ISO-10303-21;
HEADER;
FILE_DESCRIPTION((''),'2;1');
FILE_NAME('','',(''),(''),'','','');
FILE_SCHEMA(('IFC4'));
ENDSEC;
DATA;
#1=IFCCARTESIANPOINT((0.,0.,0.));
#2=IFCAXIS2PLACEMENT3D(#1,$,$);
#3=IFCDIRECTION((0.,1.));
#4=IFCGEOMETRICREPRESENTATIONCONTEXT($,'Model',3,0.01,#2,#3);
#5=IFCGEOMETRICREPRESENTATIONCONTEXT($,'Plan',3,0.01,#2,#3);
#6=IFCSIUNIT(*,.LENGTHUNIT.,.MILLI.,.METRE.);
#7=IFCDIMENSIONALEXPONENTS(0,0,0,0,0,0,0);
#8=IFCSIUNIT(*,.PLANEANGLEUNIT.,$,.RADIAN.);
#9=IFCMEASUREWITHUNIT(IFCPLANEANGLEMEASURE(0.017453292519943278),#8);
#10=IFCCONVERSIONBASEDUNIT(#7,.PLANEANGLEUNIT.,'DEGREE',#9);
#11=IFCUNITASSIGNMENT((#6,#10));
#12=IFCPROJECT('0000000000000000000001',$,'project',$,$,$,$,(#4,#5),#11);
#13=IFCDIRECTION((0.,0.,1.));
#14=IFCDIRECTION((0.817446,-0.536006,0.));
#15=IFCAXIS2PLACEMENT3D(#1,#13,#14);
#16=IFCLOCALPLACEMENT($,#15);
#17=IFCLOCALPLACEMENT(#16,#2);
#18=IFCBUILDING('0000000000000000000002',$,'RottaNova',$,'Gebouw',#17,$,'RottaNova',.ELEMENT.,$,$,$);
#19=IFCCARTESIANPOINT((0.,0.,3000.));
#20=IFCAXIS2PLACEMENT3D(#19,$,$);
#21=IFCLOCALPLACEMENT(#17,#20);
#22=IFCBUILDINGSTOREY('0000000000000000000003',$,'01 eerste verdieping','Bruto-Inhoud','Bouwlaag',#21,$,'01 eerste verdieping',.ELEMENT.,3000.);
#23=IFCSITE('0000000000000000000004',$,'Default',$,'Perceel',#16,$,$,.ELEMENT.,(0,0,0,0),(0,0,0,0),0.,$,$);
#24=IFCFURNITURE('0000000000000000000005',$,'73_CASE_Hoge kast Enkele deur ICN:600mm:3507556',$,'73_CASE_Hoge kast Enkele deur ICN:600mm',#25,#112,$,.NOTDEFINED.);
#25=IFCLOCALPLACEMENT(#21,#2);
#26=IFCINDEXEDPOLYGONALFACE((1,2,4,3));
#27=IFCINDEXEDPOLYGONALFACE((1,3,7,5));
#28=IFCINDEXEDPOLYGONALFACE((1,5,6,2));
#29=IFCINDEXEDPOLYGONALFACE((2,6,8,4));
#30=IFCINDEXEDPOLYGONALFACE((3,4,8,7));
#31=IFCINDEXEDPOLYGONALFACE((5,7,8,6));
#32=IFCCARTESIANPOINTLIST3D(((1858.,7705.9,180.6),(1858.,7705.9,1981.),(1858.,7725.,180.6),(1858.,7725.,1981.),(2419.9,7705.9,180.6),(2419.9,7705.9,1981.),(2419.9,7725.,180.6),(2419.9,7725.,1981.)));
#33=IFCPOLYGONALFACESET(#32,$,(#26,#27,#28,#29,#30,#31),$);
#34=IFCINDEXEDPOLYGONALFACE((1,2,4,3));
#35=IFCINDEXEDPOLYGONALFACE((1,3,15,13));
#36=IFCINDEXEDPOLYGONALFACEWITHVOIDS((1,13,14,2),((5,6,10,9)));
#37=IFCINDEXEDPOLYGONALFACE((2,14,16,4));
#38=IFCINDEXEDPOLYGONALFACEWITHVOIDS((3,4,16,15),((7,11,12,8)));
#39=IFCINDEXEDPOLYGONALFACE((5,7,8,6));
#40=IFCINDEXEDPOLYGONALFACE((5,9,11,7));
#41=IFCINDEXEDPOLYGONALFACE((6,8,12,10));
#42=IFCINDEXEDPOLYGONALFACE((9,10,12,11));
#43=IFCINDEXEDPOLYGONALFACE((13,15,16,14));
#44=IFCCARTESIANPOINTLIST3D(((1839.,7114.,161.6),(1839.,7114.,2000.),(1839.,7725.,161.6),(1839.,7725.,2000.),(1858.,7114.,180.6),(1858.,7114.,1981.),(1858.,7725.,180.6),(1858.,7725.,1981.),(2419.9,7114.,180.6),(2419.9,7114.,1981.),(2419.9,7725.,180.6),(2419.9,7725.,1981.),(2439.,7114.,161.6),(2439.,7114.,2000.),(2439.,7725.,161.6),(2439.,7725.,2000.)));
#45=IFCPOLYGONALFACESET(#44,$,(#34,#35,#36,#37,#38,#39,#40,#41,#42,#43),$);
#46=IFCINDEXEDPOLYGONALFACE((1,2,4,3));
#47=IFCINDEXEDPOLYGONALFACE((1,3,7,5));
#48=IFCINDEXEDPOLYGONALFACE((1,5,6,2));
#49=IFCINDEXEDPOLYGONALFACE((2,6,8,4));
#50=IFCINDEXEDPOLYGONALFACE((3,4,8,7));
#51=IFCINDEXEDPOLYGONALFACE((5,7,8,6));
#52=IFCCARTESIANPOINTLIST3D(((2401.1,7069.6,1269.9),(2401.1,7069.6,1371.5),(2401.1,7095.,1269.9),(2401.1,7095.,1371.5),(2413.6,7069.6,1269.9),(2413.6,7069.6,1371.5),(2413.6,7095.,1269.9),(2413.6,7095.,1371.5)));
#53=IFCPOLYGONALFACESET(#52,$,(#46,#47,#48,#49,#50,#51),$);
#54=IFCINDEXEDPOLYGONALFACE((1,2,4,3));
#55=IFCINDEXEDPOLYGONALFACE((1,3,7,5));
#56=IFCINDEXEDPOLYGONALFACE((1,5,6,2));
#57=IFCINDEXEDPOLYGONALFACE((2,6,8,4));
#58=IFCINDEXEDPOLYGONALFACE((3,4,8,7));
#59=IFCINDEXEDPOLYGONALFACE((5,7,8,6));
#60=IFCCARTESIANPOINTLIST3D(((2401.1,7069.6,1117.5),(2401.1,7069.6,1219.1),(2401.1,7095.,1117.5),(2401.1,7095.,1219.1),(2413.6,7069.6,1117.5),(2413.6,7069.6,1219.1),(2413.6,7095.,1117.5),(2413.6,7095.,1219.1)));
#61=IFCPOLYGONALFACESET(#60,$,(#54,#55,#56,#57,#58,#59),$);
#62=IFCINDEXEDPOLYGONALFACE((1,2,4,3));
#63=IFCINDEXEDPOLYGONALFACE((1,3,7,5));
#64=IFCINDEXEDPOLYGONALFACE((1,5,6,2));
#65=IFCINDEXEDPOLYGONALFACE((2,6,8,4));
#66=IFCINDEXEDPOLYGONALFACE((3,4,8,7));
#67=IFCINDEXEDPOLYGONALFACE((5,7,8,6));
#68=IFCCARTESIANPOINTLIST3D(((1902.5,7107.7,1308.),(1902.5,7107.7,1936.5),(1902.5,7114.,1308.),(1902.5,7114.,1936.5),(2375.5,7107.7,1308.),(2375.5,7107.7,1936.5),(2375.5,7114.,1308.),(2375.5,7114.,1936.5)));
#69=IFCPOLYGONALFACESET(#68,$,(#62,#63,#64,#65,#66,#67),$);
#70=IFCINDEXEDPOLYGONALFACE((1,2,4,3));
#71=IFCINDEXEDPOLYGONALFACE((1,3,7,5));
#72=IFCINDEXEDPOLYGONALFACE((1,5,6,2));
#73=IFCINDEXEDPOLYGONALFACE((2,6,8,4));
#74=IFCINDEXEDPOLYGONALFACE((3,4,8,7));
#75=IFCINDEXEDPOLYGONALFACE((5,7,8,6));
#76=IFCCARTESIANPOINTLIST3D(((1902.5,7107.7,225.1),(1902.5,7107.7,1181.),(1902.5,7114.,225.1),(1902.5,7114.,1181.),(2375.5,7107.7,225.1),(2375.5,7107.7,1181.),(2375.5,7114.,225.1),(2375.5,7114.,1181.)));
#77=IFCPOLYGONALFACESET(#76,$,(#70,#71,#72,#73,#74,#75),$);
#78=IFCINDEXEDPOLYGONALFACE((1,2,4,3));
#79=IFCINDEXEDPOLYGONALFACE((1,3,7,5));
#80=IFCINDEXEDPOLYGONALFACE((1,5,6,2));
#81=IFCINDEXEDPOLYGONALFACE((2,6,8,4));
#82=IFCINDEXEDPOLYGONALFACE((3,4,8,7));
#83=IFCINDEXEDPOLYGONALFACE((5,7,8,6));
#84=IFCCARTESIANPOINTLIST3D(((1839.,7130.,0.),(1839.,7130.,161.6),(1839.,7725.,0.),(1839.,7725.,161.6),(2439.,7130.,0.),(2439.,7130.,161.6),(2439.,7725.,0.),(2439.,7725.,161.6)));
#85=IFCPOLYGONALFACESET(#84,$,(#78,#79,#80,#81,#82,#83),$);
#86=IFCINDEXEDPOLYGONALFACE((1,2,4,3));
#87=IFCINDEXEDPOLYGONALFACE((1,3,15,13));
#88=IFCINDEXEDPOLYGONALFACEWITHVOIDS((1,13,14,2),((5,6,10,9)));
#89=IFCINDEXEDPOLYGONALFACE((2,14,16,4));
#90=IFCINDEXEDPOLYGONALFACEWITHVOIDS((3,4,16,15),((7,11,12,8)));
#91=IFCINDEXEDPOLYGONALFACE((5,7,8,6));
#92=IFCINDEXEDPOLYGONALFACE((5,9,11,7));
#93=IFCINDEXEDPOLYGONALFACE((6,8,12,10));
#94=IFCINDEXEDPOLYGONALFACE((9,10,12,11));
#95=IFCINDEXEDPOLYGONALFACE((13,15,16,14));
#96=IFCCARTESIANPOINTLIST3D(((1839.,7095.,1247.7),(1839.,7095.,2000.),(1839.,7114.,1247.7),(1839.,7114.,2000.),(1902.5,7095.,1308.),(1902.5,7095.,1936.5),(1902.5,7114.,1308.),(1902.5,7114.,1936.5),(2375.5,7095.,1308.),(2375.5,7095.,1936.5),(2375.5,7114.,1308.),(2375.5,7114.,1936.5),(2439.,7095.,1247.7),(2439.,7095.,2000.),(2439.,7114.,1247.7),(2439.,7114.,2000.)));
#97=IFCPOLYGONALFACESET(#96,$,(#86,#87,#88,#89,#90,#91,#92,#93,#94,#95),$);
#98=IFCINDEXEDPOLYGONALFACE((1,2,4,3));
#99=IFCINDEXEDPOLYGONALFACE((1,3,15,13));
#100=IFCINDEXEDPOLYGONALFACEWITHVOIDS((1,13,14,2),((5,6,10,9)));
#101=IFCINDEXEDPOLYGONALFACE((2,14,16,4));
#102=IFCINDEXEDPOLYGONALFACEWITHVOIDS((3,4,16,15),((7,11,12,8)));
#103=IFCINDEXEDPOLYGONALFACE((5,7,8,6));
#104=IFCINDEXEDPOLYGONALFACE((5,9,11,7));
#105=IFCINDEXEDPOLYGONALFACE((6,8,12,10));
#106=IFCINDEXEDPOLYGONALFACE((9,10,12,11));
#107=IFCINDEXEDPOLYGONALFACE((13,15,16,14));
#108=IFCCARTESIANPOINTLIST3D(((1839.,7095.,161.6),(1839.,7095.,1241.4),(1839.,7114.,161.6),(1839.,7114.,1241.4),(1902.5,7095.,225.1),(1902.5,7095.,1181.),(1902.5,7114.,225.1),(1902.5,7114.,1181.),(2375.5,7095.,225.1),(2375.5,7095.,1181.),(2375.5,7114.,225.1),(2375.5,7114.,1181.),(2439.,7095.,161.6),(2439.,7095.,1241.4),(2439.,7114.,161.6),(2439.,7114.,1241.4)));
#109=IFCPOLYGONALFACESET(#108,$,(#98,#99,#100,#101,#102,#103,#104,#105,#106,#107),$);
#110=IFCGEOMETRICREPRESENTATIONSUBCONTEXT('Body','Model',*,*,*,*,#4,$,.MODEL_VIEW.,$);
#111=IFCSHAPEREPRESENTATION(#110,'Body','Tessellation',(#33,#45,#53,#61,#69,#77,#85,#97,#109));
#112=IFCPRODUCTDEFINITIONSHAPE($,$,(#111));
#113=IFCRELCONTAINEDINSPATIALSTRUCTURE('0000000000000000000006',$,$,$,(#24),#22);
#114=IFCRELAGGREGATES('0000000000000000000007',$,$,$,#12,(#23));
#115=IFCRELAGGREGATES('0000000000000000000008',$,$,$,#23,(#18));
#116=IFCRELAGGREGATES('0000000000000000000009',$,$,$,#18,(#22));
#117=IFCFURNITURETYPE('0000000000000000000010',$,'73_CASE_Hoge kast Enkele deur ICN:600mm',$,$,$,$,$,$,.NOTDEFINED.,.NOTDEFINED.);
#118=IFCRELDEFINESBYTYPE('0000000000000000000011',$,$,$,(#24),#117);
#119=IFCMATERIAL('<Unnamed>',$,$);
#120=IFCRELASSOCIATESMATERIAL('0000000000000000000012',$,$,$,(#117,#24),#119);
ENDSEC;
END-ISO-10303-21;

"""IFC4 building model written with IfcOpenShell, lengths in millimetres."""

from ifc_helpers import new_model, entity, si_unit, converted_unit, direction, frame, origin, place, context, subcontext, project, spatial, indexed_curve, outline, extrude, source, transform, mapped, material, type_object, type_shapes, element, save


model = new_model("IFC4")

# Units and contexts
model_context = context("Model", 3, precision=0.01, world=origin(), true_north=direction((0.0, 1.0)))
plan_context = context("Plan", 3, precision=0.01, world=origin(), true_north=direction((0.0, 1.0)))
body_context = subcontext(model_context, "Body", "Model", "MODEL_VIEW")
ifc_project = project(units=[si_unit("LENGTHUNIT", "METRE", prefix="MILLI"), converted_unit("PLANEANGLEUNIT", "DEGREE", entity("IfcPlaneAngleMeasure", 0.017453292519943278), si_unit("PLANEANGLEUNIT", "RADIAN"), dimensions=[0, 0, 0, 0, 0, 0, 0])], contexts=[model_context, plan_context])

# Site, building, storey
site_placement = place(None, frame((0.0, 0.0, 0.0), z_axis=(0.0, 0.0, 1.0), x_axis=(0.817446, -0.536006, 0.0)))
site = spatial("IfcSite", under=ifc_project, at=site_placement, Name="Default", ObjectType="Perceel", CompositionType="ELEMENT", RefLatitude=(0, 0, 0, 0), RefLongitude=(0, 0, 0, 0), RefElevation=0.0)
building_placement = place(site_placement, origin())
building = spatial("IfcBuilding", under=site, at=building_placement, Name="RottaNova", ObjectType="Gebouw", LongName="RottaNova", CompositionType="ELEMENT")
storey_placement = place(building_placement, frame((0.0, 0.0, 3000.0)))
storey = spatial("IfcBuildingStorey", under=building, at=storey_placement, Name="01 eerste verdieping", Description="Bruto-Inhoud", ObjectType="Bouwlaag", LongName="01 eerste verdieping", CompositionType="ELEMENT", Elevation=3000.0)

# Furniture
ifc_material_1 = material(Name="<Unnamed>")
furniture_type = type_object("IfcFurnitureType", Name="73_CASE_Hoge kast Enkele deur ICN:600mm", AssemblyPlace="NOTDEFINED", PredefinedType="NOTDEFINED", material=ifc_material_1)
shared_shape_1 = source(origin(), body_context, "Body", "SweptSolid", [
    extrude(outline(indexed_curve([(-9.5, -280.9), (9.5, -280.9), (9.5, 280.9), (-9.5, 280.9), (-9.5, -280.9)], self_intersect=False)), frame((18.7, -9.5, 180.6), z_axis=(0.0, 0.0, 1.0), x_axis=(0.0, 1.0, 0.0)), (0.0, 0.0, 1.0), 1800.3),
    extrude(outline(indexed_curve([(-300.0, -919.2), (300.0, -919.2), (300.0, 919.2), (-300.0, 919.2), (-300.0, -919.2)], self_intersect=False), holes=[indexed_curve([(-280.9, 900.2), (281.0, 900.2), (281.0, -900.2), (-280.9, -900.2), (-280.9, 900.2)], self_intersect=False)]), frame((18.7, -610.9, 1080.8), z_axis=(0.0, 1.0, 0.0), x_axis=(-1.0, 0.0, 0.0)), (0.0, 0.0, 1.0), 610.9),
    extrude(outline(indexed_curve([(-12.7, -6.3), (12.7, -6.3), (12.7, 6.3), (-12.7, 6.3), (-12.7, -6.3)], self_intersect=False)), frame((287.1, -642.7, 1269.9), z_axis=(0.0, 0.0, 1.0), x_axis=(0.0, 1.0, 0.0)), (0.0, 0.0, 1.0), 101.6),
    extrude(outline(indexed_curve([(-12.7, -6.3), (12.7, -6.3), (12.7, 6.3), (-12.7, 6.3), (-12.7, -6.3)], self_intersect=False)), frame((287.1, -642.7, 1117.5), z_axis=(0.0, 0.0, 1.0), x_axis=(0.0, 1.0, 0.0)), (0.0, 0.0, 1.0), 101.6),
    extrude(outline(indexed_curve([(-3.2, -236.5), (3.2, -236.5), (3.2, 236.5), (-3.2, 236.5), (-3.2, -236.5)], self_intersect=False)), frame((18.7, -614.1, 1308.0), z_axis=(0.0, 0.0, 1.0), x_axis=(0.0, 1.0, 0.0)), (0.0, 0.0, 1.0), 628.5),
    extrude(outline(indexed_curve([(-3.2, -236.5), (3.2, -236.5), (3.2, 236.5), (-3.2, 236.5), (-3.2, -236.5)], self_intersect=False)), frame((18.7, -614.1, 225.1), z_axis=(0.0, 0.0, 1.0), x_axis=(0.0, 1.0, 0.0)), (0.0, 0.0, 1.0), 956.0),
    extrude(outline(indexed_curve([(-300.0, -297.5), (300.0, -297.5), (300.0, 297.5), (-300.0, 297.5), (-300.0, -297.5)], self_intersect=False)), frame((18.7, -297.5, 0.0), z_axis=(0.0, 0.0, 1.0), x_axis=(-1.0, 0.0, 0.0)), (0.0, 0.0, 1.0), 161.6),
    extrude(outline(indexed_curve([(-376.1, -300.0), (376.1, -300.0), (376.1, 300.0), (-376.1, 300.0), (-376.1, -300.0)], self_intersect=False), holes=[indexed_curve([(-312.6, -236.5), (-312.6, 236.5), (315.8, 236.5), (315.8, -236.5), (-312.6, -236.5)], self_intersect=False)]), frame((18.7, -630.0, 1623.9), z_axis=(0.0, 1.0, 0.0), x_axis=(0.0, 0.0, -1.0)), (0.0, 0.0, 1.0), 19.1),
    extrude(outline(indexed_curve([(-300.0, -539.9), (300.0, -539.9), (300.0, 539.9), (-300.0, 539.9), (-300.0, -539.9)], self_intersect=False), holes=[indexed_curve([(-236.5, 479.6), (236.5, 479.6), (236.5, -476.4), (-236.5, -476.4), (-236.5, 479.6)], self_intersect=False)]), frame((18.7, -630.0, 701.5), z_axis=(0.0, 1.0, 0.0), x_axis=(-1.0, 0.0, 0.0)), (0.0, 0.0, 1.0), 19.1),
])
type_shapes(furniture_type, [shared_shape_1])
for number, where, name in (
    (1, (2120.3, 7725.0, 0.0), "73_CASE_Hoge kast Enkele deur ICN:600mm:3507556"),
):
    element("IfcFurniture", number, at=place(storey_placement, frame(where)), inside=storey, type_object=furniture_type, material=ifc_material_1, Name=name, ObjectType="73_CASE_Hoge kast Enkele deur ICN:600mm", PredefinedType="NOTDEFINED", context=body_context, shape_type="MappedRepresentation", body=[
        mapped(shared_shape_1, transform((0.0, 0.0, 0.0), scale=1.0)),
    ])

save(model, "model.ifc")
